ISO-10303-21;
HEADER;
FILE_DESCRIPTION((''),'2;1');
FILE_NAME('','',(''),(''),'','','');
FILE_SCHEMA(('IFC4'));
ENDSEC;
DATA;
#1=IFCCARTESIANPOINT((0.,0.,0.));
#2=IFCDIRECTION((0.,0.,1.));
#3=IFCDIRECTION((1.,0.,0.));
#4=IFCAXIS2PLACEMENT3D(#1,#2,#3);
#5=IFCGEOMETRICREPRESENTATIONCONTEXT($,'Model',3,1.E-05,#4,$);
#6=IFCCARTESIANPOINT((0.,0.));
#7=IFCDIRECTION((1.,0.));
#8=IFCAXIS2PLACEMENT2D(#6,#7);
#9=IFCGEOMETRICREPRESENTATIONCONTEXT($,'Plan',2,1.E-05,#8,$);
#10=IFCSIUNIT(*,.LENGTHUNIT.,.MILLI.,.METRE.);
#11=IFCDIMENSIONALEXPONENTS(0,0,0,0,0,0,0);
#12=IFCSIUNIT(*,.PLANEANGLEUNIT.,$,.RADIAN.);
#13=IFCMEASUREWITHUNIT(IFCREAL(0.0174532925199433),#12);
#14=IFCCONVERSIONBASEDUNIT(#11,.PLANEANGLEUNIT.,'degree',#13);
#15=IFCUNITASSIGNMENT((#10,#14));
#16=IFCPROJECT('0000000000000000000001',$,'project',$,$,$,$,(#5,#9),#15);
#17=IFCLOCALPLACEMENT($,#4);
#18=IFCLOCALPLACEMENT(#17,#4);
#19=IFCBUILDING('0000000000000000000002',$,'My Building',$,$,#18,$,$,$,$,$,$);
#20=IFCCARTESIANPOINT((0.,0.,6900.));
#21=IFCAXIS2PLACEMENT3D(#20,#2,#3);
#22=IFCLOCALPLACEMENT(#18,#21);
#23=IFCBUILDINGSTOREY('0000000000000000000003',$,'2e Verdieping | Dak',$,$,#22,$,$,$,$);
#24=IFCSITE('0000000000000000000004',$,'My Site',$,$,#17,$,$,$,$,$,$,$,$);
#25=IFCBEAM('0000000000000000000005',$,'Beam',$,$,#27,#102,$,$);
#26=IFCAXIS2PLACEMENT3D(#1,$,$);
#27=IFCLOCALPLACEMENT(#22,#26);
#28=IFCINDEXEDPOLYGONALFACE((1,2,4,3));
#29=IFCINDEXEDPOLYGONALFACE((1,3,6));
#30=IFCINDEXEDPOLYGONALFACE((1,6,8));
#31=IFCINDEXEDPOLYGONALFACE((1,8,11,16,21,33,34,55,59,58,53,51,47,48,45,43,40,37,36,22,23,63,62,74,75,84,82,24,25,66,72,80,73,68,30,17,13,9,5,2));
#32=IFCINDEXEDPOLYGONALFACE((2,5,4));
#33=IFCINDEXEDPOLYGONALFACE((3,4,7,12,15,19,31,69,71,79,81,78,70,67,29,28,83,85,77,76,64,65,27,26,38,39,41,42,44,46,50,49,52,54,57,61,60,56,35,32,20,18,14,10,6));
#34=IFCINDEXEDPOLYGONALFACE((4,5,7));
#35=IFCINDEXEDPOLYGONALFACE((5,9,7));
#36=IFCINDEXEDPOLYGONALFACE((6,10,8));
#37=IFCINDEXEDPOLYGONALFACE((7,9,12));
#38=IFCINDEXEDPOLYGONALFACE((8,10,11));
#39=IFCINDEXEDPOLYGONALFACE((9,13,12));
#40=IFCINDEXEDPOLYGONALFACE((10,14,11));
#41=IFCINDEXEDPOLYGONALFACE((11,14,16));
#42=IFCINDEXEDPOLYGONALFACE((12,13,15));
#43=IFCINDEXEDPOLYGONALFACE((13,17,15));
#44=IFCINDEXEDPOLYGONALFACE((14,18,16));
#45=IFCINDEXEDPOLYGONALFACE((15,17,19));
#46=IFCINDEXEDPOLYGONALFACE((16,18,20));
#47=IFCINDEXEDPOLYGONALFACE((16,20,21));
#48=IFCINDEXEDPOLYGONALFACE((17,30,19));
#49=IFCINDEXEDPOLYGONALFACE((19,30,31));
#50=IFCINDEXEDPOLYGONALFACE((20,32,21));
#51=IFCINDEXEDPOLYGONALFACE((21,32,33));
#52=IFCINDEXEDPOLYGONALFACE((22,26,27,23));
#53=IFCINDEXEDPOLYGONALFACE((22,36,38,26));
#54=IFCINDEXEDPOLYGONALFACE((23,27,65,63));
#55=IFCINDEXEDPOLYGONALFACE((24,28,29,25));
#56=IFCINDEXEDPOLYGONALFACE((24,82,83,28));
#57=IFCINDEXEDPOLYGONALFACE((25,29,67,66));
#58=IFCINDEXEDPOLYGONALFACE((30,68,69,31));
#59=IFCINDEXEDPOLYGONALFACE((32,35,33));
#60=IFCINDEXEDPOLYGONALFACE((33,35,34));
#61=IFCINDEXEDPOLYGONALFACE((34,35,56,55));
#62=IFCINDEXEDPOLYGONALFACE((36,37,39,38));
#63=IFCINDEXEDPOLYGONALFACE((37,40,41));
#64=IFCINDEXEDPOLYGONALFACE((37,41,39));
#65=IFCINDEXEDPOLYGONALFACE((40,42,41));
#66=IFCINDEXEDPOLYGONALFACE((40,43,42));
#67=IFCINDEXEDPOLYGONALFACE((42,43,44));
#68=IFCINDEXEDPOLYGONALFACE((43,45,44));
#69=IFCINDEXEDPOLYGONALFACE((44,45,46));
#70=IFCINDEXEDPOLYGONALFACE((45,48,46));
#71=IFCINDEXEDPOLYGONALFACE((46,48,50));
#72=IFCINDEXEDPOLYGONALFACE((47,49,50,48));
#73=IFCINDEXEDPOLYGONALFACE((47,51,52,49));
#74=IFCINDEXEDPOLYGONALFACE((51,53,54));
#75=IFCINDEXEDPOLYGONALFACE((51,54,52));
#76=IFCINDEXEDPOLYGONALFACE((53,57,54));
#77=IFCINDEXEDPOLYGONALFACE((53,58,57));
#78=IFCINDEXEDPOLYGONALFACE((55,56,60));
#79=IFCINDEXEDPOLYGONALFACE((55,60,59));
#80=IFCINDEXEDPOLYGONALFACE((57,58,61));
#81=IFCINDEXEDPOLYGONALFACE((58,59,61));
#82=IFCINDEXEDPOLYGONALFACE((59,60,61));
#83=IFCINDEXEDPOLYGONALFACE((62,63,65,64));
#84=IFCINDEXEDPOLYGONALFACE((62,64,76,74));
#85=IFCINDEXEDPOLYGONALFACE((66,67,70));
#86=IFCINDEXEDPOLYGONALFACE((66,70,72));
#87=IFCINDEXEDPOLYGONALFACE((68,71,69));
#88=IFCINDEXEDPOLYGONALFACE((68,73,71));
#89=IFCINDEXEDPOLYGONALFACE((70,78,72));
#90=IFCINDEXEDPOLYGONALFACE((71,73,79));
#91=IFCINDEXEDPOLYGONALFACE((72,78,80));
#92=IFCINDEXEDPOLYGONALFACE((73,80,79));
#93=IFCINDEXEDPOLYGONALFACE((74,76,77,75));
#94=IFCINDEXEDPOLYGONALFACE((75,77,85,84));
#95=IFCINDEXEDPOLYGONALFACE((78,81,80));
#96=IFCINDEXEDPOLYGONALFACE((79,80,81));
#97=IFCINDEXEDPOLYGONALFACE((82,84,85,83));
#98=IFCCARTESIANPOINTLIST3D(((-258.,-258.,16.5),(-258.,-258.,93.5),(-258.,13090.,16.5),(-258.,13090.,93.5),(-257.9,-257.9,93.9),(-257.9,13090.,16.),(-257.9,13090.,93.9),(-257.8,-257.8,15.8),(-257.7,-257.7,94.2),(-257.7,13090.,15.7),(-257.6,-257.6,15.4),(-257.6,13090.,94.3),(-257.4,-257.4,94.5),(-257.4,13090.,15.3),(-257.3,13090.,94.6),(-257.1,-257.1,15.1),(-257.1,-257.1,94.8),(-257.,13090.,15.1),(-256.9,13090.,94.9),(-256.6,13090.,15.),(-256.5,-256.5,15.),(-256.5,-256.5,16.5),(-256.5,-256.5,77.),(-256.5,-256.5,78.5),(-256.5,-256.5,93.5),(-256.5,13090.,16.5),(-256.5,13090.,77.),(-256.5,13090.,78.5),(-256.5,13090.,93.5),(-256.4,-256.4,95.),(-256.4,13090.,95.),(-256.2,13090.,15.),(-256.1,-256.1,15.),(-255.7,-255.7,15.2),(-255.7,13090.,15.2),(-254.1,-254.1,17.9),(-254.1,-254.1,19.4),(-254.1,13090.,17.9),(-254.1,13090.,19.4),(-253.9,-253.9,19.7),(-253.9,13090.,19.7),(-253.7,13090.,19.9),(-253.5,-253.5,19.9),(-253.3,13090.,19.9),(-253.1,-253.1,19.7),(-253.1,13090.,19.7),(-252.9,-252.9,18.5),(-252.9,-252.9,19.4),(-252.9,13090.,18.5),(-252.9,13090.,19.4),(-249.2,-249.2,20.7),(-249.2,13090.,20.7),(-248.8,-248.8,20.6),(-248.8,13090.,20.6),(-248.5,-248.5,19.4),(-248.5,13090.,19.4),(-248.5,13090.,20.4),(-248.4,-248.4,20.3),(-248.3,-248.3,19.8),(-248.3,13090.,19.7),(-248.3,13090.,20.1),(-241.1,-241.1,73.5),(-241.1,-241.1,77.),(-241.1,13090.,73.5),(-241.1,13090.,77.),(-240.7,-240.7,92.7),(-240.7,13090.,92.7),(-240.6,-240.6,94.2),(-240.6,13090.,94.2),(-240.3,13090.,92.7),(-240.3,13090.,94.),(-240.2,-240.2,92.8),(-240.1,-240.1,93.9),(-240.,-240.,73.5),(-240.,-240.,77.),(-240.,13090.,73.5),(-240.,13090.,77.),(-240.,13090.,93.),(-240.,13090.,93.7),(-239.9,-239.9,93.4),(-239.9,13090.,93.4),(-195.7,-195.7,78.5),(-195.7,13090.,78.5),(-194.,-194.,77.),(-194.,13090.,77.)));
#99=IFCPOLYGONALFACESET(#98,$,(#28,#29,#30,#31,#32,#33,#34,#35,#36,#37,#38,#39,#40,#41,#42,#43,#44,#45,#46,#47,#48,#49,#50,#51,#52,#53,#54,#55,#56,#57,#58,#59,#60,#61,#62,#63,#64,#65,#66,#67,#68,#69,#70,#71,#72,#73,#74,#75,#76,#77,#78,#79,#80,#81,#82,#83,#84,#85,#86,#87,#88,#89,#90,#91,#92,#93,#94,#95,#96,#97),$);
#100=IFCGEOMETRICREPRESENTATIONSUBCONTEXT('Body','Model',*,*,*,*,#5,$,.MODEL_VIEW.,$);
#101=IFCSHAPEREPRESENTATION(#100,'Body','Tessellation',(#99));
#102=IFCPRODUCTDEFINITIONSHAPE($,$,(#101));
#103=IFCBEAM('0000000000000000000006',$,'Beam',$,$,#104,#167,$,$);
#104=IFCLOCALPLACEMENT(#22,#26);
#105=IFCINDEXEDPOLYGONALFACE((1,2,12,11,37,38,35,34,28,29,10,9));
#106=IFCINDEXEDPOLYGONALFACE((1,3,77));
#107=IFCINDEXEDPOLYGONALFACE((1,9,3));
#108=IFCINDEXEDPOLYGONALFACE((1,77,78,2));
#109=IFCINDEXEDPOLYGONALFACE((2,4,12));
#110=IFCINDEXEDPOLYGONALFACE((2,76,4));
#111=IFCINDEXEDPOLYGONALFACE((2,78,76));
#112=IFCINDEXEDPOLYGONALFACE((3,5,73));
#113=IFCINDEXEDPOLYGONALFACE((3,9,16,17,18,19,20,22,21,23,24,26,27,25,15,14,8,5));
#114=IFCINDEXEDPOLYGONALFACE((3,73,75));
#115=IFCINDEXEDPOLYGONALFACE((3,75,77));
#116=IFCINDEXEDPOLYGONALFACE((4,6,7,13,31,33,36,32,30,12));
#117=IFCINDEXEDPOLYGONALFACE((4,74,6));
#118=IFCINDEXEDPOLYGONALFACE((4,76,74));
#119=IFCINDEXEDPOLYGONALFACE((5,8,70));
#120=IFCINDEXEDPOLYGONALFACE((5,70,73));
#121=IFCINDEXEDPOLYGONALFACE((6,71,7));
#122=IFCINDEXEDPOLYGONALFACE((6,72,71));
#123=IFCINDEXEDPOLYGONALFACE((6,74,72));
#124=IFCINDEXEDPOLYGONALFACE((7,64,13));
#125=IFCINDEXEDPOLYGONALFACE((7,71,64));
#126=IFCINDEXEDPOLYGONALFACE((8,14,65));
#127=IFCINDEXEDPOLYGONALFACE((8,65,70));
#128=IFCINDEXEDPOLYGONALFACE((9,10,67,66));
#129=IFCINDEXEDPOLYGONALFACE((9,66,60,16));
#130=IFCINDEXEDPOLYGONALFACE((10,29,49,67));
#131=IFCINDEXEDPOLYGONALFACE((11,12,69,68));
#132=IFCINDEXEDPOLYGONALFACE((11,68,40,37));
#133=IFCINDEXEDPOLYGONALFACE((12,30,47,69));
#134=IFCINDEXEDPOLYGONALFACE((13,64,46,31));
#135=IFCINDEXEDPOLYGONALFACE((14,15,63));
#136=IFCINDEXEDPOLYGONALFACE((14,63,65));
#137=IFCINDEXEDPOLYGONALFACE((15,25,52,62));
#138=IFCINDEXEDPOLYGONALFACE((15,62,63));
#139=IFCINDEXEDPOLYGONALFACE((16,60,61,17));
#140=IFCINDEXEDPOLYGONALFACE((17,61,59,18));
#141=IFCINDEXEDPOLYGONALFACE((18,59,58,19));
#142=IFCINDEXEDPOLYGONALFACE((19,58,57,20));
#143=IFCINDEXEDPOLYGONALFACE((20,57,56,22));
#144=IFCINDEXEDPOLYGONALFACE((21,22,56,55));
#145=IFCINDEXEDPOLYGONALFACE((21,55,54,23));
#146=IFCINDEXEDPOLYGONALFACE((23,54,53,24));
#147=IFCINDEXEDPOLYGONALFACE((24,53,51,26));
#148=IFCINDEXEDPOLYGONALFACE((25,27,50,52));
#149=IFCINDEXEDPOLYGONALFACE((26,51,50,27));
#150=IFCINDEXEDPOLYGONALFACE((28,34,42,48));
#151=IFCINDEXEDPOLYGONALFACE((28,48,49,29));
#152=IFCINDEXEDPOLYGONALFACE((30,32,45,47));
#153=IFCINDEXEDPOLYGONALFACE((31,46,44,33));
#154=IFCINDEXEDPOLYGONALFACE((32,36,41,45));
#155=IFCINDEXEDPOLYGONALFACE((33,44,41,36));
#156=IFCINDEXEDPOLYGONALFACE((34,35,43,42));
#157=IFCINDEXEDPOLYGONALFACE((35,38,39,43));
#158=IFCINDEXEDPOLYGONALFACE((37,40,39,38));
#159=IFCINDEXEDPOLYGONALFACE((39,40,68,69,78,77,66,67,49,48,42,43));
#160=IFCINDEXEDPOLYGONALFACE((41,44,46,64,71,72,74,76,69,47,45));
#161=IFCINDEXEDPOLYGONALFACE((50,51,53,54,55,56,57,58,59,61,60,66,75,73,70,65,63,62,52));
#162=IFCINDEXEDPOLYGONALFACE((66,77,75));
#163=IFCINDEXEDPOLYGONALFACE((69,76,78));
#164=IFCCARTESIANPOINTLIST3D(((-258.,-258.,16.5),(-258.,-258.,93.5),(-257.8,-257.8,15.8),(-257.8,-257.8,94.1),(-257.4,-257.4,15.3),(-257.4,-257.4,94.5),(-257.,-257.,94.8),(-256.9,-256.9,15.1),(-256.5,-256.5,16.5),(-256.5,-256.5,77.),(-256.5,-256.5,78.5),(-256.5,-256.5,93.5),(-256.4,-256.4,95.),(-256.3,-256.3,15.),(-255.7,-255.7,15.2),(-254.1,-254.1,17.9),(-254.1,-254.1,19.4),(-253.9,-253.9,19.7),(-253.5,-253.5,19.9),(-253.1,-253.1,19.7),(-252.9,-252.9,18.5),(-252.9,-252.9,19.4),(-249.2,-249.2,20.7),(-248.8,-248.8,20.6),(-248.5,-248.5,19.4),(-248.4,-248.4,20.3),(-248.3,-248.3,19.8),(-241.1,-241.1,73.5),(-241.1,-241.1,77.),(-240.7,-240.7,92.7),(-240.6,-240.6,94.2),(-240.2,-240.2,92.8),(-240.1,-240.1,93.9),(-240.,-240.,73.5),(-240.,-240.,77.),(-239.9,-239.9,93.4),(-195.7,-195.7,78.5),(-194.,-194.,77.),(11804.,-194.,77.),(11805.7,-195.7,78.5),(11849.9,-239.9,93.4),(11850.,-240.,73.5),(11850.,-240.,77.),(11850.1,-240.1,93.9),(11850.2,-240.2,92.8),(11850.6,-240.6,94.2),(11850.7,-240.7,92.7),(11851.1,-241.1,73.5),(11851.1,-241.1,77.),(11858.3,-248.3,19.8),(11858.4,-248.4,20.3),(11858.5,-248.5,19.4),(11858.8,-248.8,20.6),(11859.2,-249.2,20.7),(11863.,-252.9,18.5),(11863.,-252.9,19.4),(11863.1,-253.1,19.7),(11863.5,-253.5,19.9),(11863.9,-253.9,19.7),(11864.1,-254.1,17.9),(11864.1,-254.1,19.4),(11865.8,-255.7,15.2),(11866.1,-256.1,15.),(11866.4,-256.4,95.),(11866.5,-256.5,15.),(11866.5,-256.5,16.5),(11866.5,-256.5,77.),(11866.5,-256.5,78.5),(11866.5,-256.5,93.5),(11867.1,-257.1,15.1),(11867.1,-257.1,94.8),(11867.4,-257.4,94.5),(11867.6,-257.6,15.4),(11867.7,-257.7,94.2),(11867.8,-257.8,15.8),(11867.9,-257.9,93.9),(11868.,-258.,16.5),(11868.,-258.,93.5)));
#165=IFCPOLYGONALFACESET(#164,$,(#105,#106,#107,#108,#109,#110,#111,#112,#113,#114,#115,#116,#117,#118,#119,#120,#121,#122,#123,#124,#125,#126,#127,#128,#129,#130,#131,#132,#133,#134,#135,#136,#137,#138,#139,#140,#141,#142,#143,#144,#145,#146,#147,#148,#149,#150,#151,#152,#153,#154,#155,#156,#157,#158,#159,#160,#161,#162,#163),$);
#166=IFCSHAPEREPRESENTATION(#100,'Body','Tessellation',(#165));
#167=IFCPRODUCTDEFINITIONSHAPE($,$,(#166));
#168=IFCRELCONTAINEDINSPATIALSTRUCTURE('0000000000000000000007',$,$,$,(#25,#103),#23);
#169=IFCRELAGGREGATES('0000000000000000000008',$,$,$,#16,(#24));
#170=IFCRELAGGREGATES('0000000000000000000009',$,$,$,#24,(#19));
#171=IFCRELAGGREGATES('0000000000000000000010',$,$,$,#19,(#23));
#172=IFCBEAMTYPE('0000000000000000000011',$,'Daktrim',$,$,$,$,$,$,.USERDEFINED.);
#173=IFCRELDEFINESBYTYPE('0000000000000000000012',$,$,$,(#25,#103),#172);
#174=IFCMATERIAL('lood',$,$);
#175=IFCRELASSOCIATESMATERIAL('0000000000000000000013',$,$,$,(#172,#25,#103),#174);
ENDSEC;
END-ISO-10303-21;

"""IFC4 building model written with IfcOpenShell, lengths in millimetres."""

from ifc_helpers import new_model, entity, si_unit, converted_unit, frame, origin_with_axes, origin_2d_with_axis, place, context, subcontext, project, spatial, line, arc, indexed_curve, outline, extrude, clip, halfspace, material, material_profile, profile_set, profile_usage, type_object, element, save


model = new_model("IFC4")

# Units and contexts
model_context = context("Model", 3, precision=1e-05, world=origin_with_axes())
plan_context = context("Plan", 2, precision=1e-05, world=origin_2d_with_axis())
body_context = subcontext(model_context, "Body", "Model", "MODEL_VIEW")
ifc_project = project(units=[si_unit("LENGTHUNIT", "METRE", prefix="MILLI"), converted_unit("PLANEANGLEUNIT", "degree", entity("IfcReal", 0.0174532925199433), si_unit("PLANEANGLEUNIT", "RADIAN"), dimensions=[0, 0, 0, 0, 0, 0, 0])], contexts=[model_context, plan_context])

# Site, building, storey
site_placement = place(None, origin_with_axes())
site = spatial("IfcSite", under=ifc_project, at=site_placement, Name="My Site")
building_placement = place(site_placement, origin_with_axes())
building = spatial("IfcBuilding", under=site, at=building_placement, Name="My Building")
storey_placement = place(building_placement, frame((0.0, 0.0, 6900.0), z_axis=(0.0, 0.0, 1.0), x_axis=(1.0, 0.0, 0.0)))
storey = spatial("IfcBuildingStorey", under=building, at=storey_placement, Name="2e Verdieping | Dak")

# Beams
ifc_material_1 = material(Name="lood")
ifc_material_profile_1 = material_profile(ifc_material_1, outline(indexed_curve([(12.9, -58.5), (12.9, -57.6), (13.5, -57.1), (14.1, -57.6), (14.1, -59.1), (16.5, -60.5), (16.5, 0.0), (1.1, 0.0), (1.1, -3.5), (0.0, -3.5), (0.0, 0.0), (-46.0, 0.0), (-44.3, 1.5), (16.5, 1.5), (16.5, 16.5), (0.7, 15.7), (-0.1, 16.4), (0.6, 17.2), (16.4, 18.0), (17.6, 17.3), (18.0, 16.5), (18.0, -60.5), (17.2, -61.8), (15.8, -61.8), (8.5, -57.6), (8.4, -56.7), (9.2, -56.3)], segments=[line(10, 9), line(9, 8), line(8, 7), line(7, 6), line(6, 5), line(5, 4), arc(4, 3, 2), line(2, 1), line(1, 27), arc(27, 26, 25), line(25, 24), arc(24, 23, 22), line(22, 21), arc(21, 20, 19), line(19, 18), arc(18, 17, 16), line(16, 15), line(15, 14), line(14, 13), line(13, 12), line(12, 11), line(11, 10)], self_intersect=False)))
ifc_profile_set_1 = profile_set([ifc_material_profile_1], Name="lood")
ifc_profile_usage_1 = profile_usage(ifc_profile_set_1, cardinal=5)
beam_type_1 = type_object("IfcBeamType", Name="Daktrim", PredefinedType="USERDEFINED", material=ifc_profile_set_1)
beam_1_placement = place(storey_placement, frame((-240.0, -258.0, 77.0), z_axis=(0.0, 1.0, 0.0), x_axis=(-1.0, 0.0, 0.0)))
element("IfcBeam", 1, at=beam_1_placement, inside=storey, type_object=beam_type_1, material=ifc_profile_usage_1, Name="Beam", context=body_context, shape_type="Clipping", body=[
    clip(extrude(outline(indexed_curve([(12.9, -58.5), (12.9, -57.6), (13.5, -57.1), (14.1, -57.6), (14.1, -59.1), (16.5, -60.5), (16.5, 0.0), (1.1, 0.0), (1.1, -3.5), (0.0, -3.5), (0.0, 0.0), (-46.0, 0.0), (-44.3, 1.5), (16.5, 1.5), (16.5, 16.5), (0.7, 15.7), (-0.1, 16.4), (0.6, 17.2), (16.4, 18.0), (17.6, 17.3), (18.0, 16.5), (18.0, -60.5), (17.2, -61.8), (15.8, -61.8), (8.5, -57.6), (8.4, -56.7), (9.2, -56.3)], segments=[line(10, 9), line(9, 8), line(8, 7), line(7, 6), line(6, 5), line(5, 4), arc(4, 3, 2), line(2, 1), line(1, 27), arc(27, 26, 25), line(25, 24), arc(24, 23, 22), line(22, 21), arc(21, 20, 19), line(19, 18), arc(18, 17, 16), line(16, 15), line(15, 14), line(14, 13), line(13, 12), line(12, 11), line(11, 10)], self_intersect=False)), origin_with_axes(), (0.0, 0.0, 1.0), 13348.0), halfspace(frame((18.0, -6977.0, 0.0), z_axis=(-0.707107, 0.0, -0.707107), x_axis=(0.0, 1.0, 0.0)), False)),
])
ifc_profile_usage_2 = profile_usage(ifc_profile_set_1, cardinal=5)
beam_2_placement = place(storey_placement, frame((11868.0, -240.0, 77.0), z_axis=(-1.0, 0.0, 0.0), x_axis=(0.0, -1.0, 0.0)))
element("IfcBeam", 2, at=beam_2_placement, inside=storey, type_object=beam_type_1, material=ifc_profile_usage_2, Name="Beam", context=body_context, shape_type="Clipping", body=[
    clip(clip(extrude(outline(indexed_curve([(12.9, -58.5), (12.9, -57.6), (13.5, -57.1), (14.1, -57.6), (14.1, -59.1), (16.5, -60.5), (16.5, 0.0), (1.1, 0.0), (1.1, -3.5), (0.0, -3.5), (0.0, 0.0), (-46.0, 0.0), (-44.3, 1.5), (16.5, 1.5), (16.5, 16.5), (0.7, 15.7), (-0.1, 16.4), (0.6, 17.2), (16.4, 18.0), (17.6, 17.3), (18.0, 16.5), (18.0, -60.5), (17.2, -61.8), (15.8, -61.8), (8.5, -57.6), (8.4, -56.7), (9.2, -56.3)], segments=[line(10, 9), line(9, 8), line(8, 7), line(7, 6), line(6, 5), line(5, 4), arc(4, 3, 2), line(2, 1), line(1, 27), arc(27, 26, 25), line(25, 24), arc(24, 23, 22), line(22, 21), arc(21, 20, 19), line(19, 18), arc(18, 17, 16), line(16, 15), line(15, 14), line(14, 13), line(13, 12), line(12, 11), line(11, 10)], self_intersect=False)), origin_with_axes(), (0.0, 0.0, 1.0), 12126.0), halfspace(frame((18.0, -6977.0, 0.0), z_axis=(-0.707107, 0.0, -0.707106), x_axis=(0.0, 1.0, 0.0)), False)), halfspace(frame((18.0, -6977.0, 12126.0), z_axis=(-0.707107, 0.0, 0.707107), x_axis=(0.0, 1.0, 0.0)), False)),
])

save(model, "model.ifc")
